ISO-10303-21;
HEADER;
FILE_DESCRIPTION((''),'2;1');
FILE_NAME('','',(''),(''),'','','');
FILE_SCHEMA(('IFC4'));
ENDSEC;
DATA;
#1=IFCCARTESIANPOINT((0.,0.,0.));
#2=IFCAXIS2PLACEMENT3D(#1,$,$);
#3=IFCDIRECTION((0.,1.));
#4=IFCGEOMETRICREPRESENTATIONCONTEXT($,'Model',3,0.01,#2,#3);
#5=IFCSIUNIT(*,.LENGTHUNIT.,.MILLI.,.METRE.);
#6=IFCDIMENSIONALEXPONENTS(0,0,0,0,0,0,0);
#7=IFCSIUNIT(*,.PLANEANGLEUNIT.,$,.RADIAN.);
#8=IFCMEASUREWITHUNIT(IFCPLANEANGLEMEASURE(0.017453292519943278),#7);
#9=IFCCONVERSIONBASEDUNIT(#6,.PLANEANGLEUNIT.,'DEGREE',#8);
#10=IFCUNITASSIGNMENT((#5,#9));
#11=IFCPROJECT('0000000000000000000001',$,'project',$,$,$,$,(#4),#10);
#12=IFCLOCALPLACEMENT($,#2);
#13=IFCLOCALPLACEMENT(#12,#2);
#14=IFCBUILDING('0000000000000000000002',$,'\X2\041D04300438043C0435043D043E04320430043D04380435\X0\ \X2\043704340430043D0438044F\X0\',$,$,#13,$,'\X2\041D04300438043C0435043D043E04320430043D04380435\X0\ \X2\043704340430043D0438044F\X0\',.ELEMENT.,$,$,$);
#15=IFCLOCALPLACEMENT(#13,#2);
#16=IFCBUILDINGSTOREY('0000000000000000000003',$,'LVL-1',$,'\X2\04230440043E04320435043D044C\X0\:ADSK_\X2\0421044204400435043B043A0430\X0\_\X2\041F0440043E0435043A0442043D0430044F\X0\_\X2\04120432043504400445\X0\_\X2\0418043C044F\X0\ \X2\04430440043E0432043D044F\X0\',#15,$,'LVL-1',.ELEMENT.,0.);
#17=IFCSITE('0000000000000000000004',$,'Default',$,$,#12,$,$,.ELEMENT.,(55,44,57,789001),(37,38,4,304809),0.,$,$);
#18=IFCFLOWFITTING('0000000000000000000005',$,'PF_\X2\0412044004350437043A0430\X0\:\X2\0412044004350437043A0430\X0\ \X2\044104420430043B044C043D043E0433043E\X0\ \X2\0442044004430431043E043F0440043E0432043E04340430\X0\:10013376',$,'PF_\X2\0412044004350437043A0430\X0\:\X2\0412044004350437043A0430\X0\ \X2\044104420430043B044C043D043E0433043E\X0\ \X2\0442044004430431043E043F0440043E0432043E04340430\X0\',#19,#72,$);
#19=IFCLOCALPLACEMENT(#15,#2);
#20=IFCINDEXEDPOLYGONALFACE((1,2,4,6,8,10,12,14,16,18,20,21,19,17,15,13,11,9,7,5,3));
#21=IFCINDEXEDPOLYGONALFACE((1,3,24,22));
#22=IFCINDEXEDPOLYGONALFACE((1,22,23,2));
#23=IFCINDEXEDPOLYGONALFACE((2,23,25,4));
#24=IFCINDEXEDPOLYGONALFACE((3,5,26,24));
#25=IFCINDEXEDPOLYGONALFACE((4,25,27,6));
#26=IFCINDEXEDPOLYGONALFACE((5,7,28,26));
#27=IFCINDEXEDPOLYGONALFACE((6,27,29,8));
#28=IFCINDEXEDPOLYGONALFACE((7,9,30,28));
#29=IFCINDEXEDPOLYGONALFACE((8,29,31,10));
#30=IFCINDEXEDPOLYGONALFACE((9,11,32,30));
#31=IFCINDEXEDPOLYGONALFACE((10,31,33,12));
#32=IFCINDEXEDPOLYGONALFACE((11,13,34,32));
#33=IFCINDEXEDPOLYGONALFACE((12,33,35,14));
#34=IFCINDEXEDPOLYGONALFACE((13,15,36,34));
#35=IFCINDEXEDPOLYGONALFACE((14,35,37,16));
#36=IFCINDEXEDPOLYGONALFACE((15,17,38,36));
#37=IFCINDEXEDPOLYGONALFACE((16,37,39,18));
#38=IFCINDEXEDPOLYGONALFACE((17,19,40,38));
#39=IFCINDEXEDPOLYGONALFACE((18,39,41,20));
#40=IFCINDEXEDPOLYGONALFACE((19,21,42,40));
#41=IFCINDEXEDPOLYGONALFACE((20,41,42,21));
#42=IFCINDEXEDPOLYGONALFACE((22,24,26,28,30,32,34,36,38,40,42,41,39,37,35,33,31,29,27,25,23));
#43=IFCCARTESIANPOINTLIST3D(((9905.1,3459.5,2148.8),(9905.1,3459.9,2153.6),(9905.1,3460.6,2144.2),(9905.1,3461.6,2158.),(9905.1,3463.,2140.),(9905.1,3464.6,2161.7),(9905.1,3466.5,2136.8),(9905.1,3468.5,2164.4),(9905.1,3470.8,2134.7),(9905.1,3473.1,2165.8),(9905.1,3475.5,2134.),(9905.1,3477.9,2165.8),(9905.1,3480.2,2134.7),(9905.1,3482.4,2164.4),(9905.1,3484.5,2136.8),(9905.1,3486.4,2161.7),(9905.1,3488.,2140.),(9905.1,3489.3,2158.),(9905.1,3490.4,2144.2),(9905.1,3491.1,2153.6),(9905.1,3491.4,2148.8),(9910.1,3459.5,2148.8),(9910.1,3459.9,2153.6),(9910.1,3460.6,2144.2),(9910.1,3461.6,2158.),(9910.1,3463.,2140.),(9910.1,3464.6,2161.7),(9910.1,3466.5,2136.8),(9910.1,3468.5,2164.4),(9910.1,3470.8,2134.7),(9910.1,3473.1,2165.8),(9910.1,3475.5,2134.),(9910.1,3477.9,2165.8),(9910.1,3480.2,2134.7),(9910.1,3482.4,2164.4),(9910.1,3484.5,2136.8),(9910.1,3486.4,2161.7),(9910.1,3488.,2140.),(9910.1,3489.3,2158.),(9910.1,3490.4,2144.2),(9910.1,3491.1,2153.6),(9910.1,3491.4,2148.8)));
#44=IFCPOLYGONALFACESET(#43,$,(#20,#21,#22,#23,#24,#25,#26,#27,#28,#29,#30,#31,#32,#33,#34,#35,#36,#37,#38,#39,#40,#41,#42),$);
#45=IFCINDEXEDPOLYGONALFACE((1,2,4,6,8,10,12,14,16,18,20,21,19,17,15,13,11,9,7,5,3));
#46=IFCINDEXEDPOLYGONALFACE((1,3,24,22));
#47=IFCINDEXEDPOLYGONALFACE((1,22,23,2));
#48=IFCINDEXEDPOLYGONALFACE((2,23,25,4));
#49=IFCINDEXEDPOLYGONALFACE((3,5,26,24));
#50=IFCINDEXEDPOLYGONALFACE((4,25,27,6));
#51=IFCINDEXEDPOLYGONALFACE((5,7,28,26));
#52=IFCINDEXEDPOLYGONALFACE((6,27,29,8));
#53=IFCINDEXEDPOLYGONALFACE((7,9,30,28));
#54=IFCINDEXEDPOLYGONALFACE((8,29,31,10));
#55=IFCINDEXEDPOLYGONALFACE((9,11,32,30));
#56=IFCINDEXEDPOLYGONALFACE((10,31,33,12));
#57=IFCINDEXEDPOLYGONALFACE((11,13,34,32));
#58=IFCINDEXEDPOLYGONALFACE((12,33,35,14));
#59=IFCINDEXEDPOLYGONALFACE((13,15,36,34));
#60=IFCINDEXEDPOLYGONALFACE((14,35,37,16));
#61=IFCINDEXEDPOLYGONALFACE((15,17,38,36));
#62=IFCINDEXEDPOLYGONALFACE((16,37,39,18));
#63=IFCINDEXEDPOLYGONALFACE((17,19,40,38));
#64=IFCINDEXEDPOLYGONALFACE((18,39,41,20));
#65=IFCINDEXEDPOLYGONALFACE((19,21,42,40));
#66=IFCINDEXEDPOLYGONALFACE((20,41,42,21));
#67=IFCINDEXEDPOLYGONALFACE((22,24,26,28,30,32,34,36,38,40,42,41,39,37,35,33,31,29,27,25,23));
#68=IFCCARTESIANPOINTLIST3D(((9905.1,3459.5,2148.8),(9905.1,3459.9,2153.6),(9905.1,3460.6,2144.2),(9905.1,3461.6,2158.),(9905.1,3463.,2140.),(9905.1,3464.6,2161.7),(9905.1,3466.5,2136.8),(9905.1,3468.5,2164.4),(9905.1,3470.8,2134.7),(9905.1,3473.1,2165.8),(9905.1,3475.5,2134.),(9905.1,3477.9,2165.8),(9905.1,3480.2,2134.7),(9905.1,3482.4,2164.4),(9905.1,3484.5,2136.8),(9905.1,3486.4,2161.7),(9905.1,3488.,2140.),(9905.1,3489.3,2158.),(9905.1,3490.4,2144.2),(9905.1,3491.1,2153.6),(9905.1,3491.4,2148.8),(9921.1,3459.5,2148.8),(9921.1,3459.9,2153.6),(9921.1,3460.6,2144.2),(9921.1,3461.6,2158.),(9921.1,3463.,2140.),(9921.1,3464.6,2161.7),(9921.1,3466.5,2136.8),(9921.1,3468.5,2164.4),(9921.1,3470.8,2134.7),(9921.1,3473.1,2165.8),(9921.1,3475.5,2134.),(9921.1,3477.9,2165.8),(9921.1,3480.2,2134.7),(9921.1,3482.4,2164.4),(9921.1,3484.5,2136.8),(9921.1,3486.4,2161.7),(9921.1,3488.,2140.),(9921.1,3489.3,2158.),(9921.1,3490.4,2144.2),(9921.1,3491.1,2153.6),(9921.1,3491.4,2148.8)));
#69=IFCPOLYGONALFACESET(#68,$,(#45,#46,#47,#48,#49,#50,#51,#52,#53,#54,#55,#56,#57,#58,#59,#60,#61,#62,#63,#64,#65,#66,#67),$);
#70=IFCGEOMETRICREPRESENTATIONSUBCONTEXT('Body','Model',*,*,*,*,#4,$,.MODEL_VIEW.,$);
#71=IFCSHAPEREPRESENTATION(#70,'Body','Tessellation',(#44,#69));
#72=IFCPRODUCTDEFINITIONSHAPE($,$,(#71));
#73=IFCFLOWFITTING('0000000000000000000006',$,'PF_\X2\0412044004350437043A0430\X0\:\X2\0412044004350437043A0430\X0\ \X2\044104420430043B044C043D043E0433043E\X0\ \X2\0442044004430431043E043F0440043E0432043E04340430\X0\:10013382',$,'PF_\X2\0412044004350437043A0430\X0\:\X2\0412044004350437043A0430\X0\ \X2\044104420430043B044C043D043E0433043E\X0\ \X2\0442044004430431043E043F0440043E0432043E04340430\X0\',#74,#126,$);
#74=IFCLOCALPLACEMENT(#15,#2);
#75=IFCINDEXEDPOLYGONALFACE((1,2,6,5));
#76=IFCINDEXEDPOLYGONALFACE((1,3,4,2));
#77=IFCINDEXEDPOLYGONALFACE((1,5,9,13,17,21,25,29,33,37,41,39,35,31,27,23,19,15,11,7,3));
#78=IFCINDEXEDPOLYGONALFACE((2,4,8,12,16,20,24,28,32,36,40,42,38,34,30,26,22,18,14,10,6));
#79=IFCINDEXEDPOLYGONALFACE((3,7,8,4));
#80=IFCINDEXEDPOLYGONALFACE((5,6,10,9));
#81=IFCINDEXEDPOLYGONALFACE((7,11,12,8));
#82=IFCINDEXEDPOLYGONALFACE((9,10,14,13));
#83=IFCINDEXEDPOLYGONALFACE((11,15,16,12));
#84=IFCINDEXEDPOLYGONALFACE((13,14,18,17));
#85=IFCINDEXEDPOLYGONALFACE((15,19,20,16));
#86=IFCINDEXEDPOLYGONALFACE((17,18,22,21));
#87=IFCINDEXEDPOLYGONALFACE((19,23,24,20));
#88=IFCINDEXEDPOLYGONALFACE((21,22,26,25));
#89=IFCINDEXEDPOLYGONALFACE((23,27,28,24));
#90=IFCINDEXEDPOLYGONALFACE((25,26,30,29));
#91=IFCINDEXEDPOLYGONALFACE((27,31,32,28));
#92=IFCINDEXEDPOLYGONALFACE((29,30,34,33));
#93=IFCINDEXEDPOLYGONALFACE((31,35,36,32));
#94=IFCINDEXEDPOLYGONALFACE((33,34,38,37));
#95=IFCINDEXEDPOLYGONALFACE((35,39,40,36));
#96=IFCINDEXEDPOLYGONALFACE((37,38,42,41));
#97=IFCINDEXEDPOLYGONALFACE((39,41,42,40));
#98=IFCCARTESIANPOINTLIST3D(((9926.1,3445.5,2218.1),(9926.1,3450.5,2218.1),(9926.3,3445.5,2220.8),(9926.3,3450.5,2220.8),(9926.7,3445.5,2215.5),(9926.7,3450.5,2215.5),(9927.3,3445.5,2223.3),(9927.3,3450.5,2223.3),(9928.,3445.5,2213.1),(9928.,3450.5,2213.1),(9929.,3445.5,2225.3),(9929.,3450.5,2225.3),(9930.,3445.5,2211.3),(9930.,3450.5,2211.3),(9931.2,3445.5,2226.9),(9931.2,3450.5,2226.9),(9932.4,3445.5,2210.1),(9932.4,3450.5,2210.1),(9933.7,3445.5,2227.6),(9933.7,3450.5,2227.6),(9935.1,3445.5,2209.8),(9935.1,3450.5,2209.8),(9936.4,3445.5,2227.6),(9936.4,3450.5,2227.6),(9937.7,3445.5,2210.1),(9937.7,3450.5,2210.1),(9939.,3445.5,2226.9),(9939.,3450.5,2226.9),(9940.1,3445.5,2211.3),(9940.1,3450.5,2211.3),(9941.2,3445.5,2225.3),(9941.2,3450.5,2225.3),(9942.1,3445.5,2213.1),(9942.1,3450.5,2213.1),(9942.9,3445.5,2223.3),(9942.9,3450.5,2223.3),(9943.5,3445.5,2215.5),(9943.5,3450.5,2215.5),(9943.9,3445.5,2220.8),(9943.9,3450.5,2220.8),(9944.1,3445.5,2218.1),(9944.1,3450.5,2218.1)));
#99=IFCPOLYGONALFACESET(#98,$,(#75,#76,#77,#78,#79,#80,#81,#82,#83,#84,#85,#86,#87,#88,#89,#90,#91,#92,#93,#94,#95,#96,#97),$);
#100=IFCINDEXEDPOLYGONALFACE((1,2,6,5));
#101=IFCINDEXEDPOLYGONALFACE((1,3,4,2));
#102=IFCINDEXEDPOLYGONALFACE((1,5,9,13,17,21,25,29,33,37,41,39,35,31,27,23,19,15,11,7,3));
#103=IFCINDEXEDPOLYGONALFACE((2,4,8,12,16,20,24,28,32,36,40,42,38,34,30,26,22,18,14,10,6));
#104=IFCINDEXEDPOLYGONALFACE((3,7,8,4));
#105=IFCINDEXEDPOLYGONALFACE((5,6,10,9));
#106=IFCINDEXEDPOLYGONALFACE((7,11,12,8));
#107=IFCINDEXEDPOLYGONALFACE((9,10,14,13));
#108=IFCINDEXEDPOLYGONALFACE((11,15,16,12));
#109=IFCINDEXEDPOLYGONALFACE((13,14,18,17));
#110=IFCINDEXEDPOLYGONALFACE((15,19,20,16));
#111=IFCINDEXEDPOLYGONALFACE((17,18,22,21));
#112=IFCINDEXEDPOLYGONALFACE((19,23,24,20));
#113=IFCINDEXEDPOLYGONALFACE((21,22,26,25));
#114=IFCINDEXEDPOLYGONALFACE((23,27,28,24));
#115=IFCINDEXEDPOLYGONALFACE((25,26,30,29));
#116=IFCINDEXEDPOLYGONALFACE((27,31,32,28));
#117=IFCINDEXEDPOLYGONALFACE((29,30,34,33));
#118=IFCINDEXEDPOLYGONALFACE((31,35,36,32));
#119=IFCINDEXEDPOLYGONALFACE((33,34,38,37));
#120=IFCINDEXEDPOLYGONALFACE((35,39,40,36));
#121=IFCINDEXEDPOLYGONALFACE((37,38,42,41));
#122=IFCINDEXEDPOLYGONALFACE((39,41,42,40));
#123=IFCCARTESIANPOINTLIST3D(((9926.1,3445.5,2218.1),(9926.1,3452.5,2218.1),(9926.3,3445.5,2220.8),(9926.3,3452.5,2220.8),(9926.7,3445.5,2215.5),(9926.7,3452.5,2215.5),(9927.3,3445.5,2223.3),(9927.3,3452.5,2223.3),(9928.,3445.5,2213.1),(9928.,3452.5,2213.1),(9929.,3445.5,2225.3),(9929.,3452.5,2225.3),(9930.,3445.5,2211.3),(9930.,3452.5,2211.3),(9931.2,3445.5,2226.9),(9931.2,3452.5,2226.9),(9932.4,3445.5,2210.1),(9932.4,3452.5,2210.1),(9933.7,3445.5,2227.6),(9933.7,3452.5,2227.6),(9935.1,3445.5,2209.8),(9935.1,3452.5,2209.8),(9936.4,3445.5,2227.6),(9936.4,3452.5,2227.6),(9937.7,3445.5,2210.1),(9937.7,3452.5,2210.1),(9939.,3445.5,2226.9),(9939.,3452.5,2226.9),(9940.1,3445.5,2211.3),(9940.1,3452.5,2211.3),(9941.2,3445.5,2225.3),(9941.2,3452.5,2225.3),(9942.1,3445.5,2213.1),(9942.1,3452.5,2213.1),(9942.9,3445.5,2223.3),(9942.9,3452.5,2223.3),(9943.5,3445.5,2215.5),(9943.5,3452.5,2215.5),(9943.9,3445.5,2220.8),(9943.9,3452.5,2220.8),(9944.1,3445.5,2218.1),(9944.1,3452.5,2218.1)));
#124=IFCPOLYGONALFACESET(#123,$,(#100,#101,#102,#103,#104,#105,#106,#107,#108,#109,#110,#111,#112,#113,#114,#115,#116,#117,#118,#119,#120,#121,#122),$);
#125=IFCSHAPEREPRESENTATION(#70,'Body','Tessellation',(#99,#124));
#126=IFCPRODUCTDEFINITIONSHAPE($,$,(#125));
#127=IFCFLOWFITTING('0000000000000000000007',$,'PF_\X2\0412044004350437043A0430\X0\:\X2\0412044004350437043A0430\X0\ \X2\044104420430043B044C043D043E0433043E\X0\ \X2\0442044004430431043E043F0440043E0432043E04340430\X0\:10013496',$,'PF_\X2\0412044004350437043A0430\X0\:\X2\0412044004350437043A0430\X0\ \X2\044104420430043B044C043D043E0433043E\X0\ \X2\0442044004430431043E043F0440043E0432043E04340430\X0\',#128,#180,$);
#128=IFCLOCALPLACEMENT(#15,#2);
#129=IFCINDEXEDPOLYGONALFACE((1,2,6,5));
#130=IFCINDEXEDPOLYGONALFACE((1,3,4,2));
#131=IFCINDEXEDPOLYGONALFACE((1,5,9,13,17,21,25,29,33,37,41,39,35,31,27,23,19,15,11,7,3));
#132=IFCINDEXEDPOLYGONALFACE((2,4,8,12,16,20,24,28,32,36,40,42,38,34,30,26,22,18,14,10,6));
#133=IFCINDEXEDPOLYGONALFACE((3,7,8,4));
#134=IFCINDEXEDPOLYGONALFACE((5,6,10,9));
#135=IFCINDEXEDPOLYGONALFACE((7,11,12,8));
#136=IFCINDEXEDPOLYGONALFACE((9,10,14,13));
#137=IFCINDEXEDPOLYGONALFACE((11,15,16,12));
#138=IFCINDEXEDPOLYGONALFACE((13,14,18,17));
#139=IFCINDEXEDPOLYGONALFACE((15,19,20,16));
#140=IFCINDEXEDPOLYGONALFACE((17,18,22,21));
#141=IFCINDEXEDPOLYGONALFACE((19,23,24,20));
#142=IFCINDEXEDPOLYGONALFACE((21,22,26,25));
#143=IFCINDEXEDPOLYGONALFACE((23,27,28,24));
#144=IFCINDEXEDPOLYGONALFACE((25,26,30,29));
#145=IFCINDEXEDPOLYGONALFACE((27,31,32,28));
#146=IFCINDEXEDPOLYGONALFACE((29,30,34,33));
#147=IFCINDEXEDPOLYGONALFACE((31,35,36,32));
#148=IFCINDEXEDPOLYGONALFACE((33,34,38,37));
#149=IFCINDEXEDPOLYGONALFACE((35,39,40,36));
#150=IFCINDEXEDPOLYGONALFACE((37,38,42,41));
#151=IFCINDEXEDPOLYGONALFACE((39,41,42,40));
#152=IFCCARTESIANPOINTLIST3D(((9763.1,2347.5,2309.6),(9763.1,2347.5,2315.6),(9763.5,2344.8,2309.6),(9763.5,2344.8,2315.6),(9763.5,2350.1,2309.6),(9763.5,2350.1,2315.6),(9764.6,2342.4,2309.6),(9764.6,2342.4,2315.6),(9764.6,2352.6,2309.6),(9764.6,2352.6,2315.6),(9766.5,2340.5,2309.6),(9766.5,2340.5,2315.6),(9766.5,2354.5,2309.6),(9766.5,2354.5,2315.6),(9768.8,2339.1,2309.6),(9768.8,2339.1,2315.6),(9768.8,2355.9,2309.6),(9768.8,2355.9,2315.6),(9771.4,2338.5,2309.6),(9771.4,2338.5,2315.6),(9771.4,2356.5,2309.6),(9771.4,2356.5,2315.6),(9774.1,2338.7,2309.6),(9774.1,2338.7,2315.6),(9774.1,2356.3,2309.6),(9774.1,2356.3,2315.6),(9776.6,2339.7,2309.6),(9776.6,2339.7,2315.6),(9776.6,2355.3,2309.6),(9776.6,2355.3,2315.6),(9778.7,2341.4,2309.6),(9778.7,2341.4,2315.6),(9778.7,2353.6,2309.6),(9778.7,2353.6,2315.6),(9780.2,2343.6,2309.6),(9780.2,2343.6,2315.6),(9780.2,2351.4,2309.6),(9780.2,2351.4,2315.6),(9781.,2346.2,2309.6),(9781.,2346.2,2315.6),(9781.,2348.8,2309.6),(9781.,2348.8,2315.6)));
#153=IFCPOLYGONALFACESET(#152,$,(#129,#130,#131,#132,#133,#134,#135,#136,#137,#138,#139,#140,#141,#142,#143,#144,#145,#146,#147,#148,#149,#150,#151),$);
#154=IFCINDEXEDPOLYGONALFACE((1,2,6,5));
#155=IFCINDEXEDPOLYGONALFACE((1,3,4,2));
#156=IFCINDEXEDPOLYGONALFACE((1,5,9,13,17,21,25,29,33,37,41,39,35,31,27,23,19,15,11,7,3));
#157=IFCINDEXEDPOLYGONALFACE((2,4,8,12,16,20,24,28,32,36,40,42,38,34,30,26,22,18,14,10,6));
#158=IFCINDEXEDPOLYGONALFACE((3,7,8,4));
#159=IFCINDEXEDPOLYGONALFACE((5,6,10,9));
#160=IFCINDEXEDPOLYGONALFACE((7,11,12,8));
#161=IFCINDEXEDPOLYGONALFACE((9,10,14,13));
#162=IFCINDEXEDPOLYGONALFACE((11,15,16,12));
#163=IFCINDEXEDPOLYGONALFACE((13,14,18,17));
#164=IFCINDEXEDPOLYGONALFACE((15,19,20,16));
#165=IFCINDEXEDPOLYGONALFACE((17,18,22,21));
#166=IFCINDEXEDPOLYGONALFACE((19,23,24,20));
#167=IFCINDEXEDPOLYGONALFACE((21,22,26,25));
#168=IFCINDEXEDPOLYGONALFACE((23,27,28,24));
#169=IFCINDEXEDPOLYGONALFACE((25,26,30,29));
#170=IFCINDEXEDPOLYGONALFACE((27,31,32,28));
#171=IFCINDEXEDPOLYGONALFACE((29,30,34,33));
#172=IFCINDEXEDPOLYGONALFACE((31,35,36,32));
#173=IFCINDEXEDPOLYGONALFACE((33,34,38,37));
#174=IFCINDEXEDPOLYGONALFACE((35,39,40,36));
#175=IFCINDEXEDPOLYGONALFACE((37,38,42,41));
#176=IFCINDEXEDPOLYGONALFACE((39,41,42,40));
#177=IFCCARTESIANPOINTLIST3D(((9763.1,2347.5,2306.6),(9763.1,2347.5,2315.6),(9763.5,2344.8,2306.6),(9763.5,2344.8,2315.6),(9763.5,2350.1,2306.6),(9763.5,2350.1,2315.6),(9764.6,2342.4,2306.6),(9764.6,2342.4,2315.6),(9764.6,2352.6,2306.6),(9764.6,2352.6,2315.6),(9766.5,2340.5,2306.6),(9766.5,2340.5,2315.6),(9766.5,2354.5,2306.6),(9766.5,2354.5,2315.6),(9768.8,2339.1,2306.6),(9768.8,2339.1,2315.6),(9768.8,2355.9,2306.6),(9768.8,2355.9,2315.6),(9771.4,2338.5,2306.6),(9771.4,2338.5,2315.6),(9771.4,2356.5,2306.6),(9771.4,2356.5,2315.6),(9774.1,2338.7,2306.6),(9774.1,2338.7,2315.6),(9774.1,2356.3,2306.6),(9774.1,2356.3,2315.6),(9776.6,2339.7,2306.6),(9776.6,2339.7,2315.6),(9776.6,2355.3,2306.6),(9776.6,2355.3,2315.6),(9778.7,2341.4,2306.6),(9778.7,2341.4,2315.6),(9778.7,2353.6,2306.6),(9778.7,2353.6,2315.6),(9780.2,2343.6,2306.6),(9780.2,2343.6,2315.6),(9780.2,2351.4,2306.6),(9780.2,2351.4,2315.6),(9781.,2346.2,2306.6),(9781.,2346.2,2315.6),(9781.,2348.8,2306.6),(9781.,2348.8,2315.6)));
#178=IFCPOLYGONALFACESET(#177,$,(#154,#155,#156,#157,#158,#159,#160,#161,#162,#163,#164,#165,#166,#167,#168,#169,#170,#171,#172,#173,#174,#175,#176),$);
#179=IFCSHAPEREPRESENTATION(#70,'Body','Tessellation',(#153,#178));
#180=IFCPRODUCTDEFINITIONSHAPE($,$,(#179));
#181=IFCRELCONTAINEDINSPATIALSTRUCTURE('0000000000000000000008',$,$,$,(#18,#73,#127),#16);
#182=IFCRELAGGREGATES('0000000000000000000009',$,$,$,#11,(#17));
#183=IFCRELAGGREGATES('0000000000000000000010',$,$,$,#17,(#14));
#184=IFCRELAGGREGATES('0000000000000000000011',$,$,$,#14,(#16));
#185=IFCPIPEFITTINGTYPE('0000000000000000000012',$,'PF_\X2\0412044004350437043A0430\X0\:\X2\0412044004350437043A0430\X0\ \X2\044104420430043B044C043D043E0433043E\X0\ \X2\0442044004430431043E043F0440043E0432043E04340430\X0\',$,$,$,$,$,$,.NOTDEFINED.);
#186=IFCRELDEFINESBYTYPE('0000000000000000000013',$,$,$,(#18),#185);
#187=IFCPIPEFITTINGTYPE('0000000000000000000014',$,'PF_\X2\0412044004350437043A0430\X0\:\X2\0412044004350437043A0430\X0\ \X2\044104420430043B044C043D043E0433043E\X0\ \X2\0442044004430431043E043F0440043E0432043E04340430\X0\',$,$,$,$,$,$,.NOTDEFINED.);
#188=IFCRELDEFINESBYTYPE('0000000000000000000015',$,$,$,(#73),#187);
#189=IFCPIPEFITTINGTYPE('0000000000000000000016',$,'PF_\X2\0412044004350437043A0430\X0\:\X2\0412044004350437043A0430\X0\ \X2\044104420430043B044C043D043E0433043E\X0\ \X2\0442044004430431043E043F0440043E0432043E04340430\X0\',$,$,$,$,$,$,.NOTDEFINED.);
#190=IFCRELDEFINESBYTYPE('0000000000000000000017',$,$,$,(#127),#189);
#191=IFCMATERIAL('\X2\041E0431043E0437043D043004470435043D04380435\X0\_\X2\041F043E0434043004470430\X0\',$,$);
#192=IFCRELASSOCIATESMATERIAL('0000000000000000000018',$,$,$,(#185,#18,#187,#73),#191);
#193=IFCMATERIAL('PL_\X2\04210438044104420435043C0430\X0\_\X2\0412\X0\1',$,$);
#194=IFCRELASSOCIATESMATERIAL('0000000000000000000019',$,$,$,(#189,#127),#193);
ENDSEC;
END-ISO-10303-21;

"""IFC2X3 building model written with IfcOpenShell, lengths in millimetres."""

from ifc_helpers import new_model, entity, si_unit, converted_unit, direction, frame, frame_2d, origin, place, context, subcontext, project, spatial, circle, extrude, source, transform, mapped, material, type_object, type_shapes, element, save


model = new_model("IFC2X3")

# Units and contexts
model_context = context("Model", 3, precision=0.01, world=origin(), true_north=direction((0.0, 1.0)))
body_context = subcontext(model_context, "Body", "Model", "MODEL_VIEW")
ifc_project = project(units=[si_unit("LENGTHUNIT", "METRE", prefix="MILLI"), converted_unit("PLANEANGLEUNIT", "DEGREE", entity("IfcPlaneAngleMeasure", 0.017453292519943278), si_unit("PLANEANGLEUNIT", "RADIAN"), dimensions=[0, 0, 0, 0, 0, 0, 0])], contexts=[model_context])

# Site, building, storey
site_placement = place(None, origin())
site = spatial("IfcSite", under=ifc_project, at=site_placement, Name="Default", CompositionType="ELEMENT", RefLatitude=(55, 44, 57, 789001), RefLongitude=(37, 38, 4, 304809), RefElevation=0.0)
building_placement = place(site_placement, origin())
building = spatial("IfcBuilding", under=site, at=building_placement, Name="Наименование здания", LongName="Наименование здания", CompositionType="ELEMENT")
storey_placement = place(building_placement, origin())
storey = spatial("IfcBuildingStorey", under=building, at=storey_placement, Name="LVL-1", ObjectType="Уровень:ADSK_Стрелка_Проектная_Вверх_Имя уровня", LongName="LVL-1", CompositionType="ELEMENT", Elevation=0.0)

# Shared definitions
ifc_material_1 = material(Name="Обозначение_Подача")

# Flow fittings
pipe_fitting_type_1 = type_object("IfcPipeFittingType", Name="PF_Врезка:Врезка стального трубопровода", PredefinedType="NOTDEFINED", material=ifc_material_1)
shared_shape_1 = source(origin(), body_context, "Body", "SweptSolid", [
    extrude(circle(Radius=16.0, at=frame_2d((0.0, 0.0), x_axis=(1.0, 0.0))), frame((-5.0, 0.0, 0.0), z_axis=(1.0, 0.0, 0.0), x_axis=(0.0, -1.0, 0.0)), (0.0, 0.0, 1.0), 5.0),
    extrude(circle(Radius=16.0, at=frame_2d((0.0, 0.0), x_axis=(1.0, 0.0))), frame((-16.0, 0.0, 0.0), z_axis=(1.0, 0.0, 0.0), x_axis=(0.0, -1.0, 0.0)), (0.0, 0.0, 1.0), 16.0),
])
type_shapes(pipe_fitting_type_1, [shared_shape_1])
flow_fitting_1_placement = place(storey_placement, frame((9905.1, 3475.5, 2150.0), z_axis=(0.0, 1.0, 0.0), x_axis=(-1.0, 0.0, 0.0)))
element("IfcFlowFitting", 1, at=flow_fitting_1_placement, inside=storey, type_object=pipe_fitting_type_1, material=ifc_material_1, Name="PF_Врезка:Врезка стального трубопровода:10013376", ObjectType="PF_Врезка:Врезка стального трубопровода", context=body_context, shape_type="MappedRepresentation", body=[
    mapped(shared_shape_1, transform((0.0, 0.0, 0.0), scale=1.0)),
])
pipe_fitting_type_2 = type_object("IfcPipeFittingType", Name="PF_Врезка:Врезка стального трубопровода", PredefinedType="NOTDEFINED", material=ifc_material_1)
shared_shape_2 = source(origin(), body_context, "Body", "SweptSolid", [
    extrude(circle(Radius=9.0, at=frame_2d((0.0, 0.0), x_axis=(1.0, 0.0))), frame((-5.0, 0.0, 0.0), z_axis=(1.0, 0.0, 0.0), x_axis=(0.0, -1.0, 0.0)), (0.0, 0.0, 1.0), 5.0),
    extrude(circle(Radius=9.0, at=frame_2d((0.0, 0.0), x_axis=(1.0, 0.0))), frame((-7.0, 0.0, 0.0), z_axis=(1.0, 0.0, 0.0), x_axis=(0.0, -1.0, 0.0)), (0.0, 0.0, 1.0), 7.0),
])
type_shapes(pipe_fitting_type_2, [shared_shape_2])
flow_fitting_2_placement = place(storey_placement, frame((9935.1, 3445.5, 2218.8), z_axis=(-1.0, 0.0, 0.0), x_axis=(0.0, -1.0, 0.0)))
element("IfcFlowFitting", 2, at=flow_fitting_2_placement, inside=storey, type_object=pipe_fitting_type_2, material=ifc_material_1, Name="PF_Врезка:Врезка стального трубопровода:10013382", ObjectType="PF_Врезка:Врезка стального трубопровода", context=body_context, shape_type="MappedRepresentation", body=[
    mapped(shared_shape_2, transform((0.0, 0.0, 0.0), scale=1.0)),
])
ifc_material_2 = material(Name="PL_Система_В1")
pipe_fitting_type_3 = type_object("IfcPipeFittingType", Name="PF_Врезка:Врезка стального трубопровода", PredefinedType="NOTDEFINED", material=ifc_material_2)
shared_shape_3 = source(origin(), body_context, "Body", "SweptSolid", [
    extrude(circle(Radius=9.0, at=frame_2d((0.0, 0.0), x_axis=(1.0, 0.0))), frame((-6.0, 0.0, 0.0), z_axis=(1.0, 0.0, 0.0), x_axis=(0.0, 1.0, 0.0)), (0.0, 0.0, 1.0), 6.0),
    extrude(circle(Radius=9.0, at=frame_2d((0.0, 0.0), x_axis=(1.0, 0.0))), frame((-9.0, 0.0, 0.0), z_axis=(1.0, 0.0, 0.0), x_axis=(0.0, 1.0, 0.0)), (0.0, 0.0, 1.0), 9.0),
])
type_shapes(pipe_fitting_type_3, [shared_shape_3])
flow_fitting_3_placement = place(storey_placement, frame((9772.1, 2347.5, 2315.6), z_axis=(0.0, -1.0, 0.0), x_axis=(0.0, 0.0, 1.0)))
element("IfcFlowFitting", 3, at=flow_fitting_3_placement, inside=storey, type_object=pipe_fitting_type_3, material=ifc_material_2, Name="PF_Врезка:Врезка стального трубопровода:10013496", ObjectType="PF_Врезка:Врезка стального трубопровода", context=body_context, shape_type="MappedRepresentation", body=[
    mapped(shared_shape_3, transform((0.0, 0.0, 0.0), scale=1.0)),
])

save(model, "model.ifc")
